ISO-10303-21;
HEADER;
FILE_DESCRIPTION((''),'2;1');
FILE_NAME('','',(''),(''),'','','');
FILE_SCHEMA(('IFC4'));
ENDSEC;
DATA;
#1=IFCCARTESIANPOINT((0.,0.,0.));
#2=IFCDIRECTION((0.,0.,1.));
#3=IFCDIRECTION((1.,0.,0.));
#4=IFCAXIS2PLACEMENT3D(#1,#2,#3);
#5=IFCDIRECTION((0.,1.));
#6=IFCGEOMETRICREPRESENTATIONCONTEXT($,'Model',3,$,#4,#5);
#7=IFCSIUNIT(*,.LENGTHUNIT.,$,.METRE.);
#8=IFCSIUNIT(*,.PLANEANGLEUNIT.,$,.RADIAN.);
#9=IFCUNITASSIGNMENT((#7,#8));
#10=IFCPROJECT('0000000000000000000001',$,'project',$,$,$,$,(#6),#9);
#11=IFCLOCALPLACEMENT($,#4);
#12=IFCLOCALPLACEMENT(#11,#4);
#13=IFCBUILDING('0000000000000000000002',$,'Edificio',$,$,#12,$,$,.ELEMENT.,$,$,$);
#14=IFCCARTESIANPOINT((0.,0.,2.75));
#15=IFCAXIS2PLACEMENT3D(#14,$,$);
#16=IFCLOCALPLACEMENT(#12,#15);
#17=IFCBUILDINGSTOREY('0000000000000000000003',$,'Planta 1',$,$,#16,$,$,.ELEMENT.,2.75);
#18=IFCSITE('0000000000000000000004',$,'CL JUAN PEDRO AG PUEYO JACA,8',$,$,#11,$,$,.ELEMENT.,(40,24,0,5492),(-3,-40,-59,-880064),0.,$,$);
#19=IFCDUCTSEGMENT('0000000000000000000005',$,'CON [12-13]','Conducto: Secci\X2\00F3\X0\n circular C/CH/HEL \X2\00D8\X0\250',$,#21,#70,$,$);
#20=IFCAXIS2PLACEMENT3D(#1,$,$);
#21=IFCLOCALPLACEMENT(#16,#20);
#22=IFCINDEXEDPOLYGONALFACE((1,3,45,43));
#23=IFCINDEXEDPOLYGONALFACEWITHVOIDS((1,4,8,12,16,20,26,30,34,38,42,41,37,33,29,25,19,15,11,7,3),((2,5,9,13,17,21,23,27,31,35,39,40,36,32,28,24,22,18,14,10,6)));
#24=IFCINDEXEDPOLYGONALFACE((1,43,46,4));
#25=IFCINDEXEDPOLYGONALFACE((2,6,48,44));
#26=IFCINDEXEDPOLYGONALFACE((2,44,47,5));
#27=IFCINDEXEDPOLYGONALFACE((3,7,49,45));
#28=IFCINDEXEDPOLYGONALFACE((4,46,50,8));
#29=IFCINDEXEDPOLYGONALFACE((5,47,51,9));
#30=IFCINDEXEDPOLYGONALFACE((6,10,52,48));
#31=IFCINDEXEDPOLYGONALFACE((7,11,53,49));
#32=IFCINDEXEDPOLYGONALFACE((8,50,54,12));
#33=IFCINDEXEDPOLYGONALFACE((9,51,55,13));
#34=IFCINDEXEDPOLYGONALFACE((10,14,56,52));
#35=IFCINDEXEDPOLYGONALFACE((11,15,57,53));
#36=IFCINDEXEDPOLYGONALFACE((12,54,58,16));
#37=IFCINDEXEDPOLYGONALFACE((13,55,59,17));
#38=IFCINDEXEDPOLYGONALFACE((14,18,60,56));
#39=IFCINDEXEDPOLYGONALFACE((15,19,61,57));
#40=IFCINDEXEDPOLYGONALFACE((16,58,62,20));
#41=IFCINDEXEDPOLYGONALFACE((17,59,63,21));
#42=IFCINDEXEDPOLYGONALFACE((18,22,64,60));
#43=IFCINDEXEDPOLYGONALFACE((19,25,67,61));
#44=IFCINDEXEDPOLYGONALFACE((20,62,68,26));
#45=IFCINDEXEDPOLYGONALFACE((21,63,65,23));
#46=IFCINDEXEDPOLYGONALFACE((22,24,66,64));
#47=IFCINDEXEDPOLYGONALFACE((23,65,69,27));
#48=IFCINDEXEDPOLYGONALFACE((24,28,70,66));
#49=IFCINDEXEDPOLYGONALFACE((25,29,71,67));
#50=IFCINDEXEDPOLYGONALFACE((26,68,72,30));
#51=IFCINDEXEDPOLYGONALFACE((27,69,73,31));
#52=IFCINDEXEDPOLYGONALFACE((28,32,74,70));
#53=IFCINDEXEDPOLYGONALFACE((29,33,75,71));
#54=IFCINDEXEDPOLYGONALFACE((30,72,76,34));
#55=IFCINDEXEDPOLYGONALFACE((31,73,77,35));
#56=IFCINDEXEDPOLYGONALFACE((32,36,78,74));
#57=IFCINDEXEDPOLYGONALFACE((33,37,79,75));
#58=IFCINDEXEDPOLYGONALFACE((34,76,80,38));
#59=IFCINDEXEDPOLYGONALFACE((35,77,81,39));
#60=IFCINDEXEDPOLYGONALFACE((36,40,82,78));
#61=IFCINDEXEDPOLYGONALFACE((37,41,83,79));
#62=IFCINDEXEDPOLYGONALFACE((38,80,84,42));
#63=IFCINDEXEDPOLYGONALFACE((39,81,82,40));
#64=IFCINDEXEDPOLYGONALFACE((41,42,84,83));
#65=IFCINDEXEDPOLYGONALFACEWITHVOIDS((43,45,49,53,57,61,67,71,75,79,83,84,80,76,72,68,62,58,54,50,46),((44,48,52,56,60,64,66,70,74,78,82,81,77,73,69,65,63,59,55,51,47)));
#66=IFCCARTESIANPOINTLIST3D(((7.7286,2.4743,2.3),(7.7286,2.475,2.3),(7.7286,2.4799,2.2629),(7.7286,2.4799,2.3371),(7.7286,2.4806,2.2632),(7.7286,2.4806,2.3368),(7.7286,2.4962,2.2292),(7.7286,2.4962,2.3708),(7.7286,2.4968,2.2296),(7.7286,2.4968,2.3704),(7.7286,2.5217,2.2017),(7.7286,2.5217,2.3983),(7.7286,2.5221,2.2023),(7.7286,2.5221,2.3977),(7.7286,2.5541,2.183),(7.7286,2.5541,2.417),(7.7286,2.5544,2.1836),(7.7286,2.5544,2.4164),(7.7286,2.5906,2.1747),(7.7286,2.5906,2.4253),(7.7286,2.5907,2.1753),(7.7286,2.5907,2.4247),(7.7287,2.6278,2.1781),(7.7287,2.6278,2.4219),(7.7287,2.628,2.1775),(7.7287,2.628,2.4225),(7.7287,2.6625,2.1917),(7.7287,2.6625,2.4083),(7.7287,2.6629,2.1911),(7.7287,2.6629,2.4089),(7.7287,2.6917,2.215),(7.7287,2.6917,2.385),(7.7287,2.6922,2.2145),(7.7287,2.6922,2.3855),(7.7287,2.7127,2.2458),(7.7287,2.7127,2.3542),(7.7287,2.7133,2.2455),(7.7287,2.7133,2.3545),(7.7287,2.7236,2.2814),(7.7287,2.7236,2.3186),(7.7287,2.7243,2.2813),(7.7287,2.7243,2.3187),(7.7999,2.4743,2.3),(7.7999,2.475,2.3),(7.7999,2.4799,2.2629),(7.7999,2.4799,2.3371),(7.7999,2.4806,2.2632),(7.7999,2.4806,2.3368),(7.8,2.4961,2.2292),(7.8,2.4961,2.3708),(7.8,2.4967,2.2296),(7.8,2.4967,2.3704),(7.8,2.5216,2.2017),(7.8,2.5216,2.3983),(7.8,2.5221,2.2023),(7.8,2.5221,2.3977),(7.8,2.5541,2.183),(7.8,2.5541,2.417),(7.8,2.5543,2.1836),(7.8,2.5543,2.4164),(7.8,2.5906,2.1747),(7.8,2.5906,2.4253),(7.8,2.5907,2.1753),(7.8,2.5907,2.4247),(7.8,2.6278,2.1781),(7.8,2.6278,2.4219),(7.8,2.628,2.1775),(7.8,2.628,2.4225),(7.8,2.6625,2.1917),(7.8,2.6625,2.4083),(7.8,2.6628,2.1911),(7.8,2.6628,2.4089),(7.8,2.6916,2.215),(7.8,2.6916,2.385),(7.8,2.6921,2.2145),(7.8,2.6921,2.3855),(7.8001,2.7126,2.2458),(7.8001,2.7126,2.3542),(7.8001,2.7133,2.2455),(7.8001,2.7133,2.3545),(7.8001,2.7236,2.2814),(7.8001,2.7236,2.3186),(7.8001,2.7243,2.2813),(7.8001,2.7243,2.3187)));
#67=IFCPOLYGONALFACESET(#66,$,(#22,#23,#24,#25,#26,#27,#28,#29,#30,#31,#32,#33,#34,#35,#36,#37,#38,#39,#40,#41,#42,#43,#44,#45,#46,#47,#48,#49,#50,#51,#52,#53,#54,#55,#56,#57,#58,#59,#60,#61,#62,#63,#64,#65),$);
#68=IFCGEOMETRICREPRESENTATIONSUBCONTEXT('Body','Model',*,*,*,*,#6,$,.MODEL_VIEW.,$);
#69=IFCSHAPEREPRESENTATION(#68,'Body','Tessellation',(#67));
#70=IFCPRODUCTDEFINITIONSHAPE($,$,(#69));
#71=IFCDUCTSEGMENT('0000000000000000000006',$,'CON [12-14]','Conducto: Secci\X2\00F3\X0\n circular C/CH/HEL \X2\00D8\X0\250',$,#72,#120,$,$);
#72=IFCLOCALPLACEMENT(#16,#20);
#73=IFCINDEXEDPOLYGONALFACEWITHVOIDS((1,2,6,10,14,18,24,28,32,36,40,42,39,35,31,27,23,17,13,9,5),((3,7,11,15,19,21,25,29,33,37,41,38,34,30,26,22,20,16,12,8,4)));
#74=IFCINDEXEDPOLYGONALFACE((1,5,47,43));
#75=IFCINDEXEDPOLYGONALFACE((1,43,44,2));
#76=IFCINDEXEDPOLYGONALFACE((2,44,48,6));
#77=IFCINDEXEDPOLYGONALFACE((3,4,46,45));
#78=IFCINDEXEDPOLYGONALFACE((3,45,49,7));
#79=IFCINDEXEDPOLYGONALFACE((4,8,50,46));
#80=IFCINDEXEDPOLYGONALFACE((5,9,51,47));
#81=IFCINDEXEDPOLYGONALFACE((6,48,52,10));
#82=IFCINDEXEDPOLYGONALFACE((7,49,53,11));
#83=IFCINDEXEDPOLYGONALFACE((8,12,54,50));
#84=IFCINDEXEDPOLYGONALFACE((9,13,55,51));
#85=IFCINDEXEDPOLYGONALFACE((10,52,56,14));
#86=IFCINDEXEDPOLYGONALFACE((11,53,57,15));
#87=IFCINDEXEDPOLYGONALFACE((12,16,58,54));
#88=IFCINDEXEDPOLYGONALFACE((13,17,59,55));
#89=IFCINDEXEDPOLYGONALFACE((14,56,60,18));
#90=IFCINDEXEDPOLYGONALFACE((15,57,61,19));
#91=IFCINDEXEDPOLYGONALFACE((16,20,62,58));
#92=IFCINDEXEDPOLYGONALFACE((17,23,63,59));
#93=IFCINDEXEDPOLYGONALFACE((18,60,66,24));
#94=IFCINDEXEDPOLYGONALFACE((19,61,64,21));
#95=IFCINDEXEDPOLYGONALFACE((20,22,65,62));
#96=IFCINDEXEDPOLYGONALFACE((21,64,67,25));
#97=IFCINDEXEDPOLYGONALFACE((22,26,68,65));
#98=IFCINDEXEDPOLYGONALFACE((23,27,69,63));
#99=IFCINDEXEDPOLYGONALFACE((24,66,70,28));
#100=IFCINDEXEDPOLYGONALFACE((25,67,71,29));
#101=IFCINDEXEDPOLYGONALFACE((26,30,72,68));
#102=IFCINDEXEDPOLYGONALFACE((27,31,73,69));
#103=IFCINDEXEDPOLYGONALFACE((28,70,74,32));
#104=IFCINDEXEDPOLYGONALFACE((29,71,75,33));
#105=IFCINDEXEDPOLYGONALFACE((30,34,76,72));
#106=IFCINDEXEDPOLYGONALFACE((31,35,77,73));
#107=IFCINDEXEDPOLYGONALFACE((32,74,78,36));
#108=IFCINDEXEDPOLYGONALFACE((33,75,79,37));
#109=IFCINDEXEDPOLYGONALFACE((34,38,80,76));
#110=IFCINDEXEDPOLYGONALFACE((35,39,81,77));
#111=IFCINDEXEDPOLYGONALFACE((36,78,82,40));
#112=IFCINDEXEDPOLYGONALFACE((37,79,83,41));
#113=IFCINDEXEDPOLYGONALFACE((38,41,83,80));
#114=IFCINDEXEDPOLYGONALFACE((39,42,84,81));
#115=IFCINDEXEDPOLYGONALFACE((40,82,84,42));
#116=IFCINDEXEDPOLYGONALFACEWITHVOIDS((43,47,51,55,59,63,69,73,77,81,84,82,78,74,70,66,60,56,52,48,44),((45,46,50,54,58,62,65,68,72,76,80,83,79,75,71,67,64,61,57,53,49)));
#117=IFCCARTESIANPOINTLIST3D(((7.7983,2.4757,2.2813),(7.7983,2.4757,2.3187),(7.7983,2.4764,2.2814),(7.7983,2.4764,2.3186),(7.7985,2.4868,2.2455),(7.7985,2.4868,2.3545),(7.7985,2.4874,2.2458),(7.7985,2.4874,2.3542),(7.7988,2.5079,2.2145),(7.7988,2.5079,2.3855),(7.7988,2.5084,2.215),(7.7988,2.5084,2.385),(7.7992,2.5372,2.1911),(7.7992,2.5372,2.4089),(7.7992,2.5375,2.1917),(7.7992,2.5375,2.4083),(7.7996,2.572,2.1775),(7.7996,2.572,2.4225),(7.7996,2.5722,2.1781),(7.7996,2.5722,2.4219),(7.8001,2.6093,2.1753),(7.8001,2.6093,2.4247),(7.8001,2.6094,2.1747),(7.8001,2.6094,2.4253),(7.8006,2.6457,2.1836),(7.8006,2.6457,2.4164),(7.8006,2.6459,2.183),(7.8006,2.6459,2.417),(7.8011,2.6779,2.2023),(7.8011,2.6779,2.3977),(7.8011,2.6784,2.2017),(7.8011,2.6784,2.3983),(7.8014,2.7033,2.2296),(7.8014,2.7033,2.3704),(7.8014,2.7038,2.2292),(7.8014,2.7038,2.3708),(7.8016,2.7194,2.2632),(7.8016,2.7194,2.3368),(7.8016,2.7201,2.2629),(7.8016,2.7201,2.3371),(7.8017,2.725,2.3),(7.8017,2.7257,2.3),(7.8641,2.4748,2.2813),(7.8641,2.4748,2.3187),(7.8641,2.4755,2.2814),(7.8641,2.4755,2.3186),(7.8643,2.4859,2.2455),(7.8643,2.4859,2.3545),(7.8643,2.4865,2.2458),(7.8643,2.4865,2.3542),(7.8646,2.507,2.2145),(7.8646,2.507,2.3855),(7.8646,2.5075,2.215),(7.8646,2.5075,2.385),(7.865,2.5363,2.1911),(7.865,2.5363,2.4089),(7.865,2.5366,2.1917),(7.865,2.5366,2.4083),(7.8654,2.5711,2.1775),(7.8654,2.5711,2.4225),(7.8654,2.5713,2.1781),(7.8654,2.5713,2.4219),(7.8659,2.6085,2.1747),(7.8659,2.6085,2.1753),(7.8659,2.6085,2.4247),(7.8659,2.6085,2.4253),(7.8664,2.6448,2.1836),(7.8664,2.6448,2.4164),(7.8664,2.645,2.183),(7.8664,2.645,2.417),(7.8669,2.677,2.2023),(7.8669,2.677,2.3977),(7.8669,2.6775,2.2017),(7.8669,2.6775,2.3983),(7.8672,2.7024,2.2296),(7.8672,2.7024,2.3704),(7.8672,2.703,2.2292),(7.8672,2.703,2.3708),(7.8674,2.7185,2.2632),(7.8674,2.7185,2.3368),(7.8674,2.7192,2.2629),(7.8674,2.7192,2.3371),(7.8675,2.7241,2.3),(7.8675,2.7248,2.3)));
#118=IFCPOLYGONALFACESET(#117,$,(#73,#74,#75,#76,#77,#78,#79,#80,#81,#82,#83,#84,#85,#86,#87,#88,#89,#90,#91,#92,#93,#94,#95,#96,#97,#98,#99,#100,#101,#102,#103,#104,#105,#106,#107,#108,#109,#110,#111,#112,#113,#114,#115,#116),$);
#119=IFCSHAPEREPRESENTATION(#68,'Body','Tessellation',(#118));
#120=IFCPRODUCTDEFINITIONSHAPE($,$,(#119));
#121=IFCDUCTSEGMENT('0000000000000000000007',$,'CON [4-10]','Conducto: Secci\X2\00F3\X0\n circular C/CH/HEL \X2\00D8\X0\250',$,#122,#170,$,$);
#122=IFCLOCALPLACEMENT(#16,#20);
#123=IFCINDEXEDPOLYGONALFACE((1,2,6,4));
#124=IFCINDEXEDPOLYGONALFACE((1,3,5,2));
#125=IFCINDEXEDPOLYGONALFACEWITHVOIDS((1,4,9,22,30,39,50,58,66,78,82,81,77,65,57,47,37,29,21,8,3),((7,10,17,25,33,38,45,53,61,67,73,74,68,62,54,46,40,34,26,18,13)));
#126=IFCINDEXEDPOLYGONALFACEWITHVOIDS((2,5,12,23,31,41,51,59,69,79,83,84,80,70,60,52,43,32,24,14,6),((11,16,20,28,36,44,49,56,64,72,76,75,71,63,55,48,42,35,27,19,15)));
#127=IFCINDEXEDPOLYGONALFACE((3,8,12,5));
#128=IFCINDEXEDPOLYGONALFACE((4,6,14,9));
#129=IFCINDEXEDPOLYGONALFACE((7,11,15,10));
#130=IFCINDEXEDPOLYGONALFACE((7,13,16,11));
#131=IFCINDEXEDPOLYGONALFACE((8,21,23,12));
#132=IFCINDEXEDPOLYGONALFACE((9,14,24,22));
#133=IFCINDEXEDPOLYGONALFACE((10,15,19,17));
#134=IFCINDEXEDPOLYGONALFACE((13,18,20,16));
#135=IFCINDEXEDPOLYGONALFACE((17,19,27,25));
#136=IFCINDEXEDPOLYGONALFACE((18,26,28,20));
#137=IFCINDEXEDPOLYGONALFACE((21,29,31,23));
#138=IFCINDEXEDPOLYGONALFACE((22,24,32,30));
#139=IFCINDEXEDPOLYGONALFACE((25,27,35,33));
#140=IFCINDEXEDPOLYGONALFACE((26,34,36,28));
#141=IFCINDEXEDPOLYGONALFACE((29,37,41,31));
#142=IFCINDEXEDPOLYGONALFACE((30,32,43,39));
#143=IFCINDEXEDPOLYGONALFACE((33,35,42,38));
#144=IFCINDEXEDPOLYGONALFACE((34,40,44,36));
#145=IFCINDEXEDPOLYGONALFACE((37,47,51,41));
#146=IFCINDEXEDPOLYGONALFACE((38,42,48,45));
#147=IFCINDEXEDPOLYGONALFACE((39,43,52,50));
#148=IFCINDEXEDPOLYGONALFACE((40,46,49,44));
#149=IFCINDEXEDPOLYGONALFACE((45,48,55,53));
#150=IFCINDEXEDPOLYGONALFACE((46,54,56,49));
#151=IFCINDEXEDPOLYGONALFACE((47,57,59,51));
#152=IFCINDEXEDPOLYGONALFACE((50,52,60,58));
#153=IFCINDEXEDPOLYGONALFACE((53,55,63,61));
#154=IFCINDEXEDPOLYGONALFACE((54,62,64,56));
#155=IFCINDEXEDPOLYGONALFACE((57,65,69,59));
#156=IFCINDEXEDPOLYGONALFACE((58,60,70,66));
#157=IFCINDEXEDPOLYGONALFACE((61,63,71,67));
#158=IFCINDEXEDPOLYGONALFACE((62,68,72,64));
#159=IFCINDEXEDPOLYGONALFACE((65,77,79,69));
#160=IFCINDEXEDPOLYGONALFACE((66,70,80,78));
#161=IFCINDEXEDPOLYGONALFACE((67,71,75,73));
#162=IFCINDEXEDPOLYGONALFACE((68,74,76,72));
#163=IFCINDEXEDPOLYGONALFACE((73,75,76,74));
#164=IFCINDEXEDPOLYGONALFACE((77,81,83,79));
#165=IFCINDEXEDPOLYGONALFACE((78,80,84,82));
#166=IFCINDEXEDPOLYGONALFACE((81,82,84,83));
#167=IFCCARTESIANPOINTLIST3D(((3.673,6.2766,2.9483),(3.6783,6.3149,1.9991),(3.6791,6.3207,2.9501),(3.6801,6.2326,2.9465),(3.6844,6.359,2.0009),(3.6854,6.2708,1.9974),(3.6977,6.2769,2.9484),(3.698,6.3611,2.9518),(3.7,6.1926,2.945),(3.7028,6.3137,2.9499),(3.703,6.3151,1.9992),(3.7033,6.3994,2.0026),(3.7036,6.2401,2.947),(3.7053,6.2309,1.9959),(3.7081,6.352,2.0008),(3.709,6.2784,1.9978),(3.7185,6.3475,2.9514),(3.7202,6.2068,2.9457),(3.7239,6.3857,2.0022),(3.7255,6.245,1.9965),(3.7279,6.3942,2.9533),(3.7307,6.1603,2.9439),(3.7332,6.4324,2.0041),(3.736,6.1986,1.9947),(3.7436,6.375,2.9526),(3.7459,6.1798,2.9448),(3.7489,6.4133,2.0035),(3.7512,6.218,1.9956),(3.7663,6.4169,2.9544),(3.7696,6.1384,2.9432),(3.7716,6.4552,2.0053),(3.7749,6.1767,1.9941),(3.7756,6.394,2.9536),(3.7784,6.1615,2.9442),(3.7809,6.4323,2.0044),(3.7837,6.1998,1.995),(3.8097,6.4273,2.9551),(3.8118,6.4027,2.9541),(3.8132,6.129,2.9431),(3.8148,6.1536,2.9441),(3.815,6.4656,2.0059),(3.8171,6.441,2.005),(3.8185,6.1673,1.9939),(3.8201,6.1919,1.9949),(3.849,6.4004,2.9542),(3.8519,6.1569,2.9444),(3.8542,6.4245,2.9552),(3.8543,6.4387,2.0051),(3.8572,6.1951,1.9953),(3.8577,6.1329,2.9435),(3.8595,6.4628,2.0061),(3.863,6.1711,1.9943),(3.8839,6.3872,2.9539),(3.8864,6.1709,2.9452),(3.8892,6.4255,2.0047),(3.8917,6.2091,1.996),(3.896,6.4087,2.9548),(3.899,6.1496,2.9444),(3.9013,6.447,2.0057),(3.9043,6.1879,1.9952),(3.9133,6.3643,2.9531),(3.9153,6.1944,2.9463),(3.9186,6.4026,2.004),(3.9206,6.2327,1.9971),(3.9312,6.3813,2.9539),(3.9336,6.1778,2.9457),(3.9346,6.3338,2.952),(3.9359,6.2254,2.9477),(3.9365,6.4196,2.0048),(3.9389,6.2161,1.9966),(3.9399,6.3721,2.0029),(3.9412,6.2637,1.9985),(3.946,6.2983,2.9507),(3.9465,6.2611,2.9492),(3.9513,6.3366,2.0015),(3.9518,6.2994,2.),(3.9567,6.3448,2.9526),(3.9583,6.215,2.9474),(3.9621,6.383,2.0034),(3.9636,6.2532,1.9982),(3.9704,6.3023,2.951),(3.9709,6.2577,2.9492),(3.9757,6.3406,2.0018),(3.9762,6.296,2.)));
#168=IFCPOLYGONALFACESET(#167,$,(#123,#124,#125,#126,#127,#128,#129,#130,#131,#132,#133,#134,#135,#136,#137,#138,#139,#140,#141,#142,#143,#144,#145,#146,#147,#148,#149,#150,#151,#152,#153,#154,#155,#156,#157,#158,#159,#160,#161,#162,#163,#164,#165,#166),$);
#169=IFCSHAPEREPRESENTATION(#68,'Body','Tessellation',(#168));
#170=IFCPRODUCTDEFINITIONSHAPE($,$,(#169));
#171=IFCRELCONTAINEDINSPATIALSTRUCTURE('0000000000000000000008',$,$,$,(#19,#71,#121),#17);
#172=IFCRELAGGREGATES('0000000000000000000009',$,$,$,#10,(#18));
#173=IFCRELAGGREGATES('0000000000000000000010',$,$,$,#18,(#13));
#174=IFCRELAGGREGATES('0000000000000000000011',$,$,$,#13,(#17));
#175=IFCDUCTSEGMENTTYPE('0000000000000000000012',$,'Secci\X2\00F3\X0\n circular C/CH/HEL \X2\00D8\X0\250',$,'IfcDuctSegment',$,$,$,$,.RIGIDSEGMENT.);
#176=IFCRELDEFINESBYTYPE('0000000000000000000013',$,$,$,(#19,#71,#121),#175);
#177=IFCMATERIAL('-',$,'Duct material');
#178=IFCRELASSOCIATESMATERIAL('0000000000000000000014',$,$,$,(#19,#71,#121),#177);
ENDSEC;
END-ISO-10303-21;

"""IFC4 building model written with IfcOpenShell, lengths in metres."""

from ifc_helpers import new_model, si_unit, direction, frame, origin_with_axes, origin_2d_with_axis, place, context, subcontext, project, spatial, hollow_circle, extrude, material, type_object, element, save


model = new_model("IFC4")

# Units and contexts
model_context = context("Model", 3, world=origin_with_axes(), true_north=direction((0.0, 1.0)))
body_context = subcontext(model_context, "Body", "Model", "MODEL_VIEW")
ifc_project = project(units=[si_unit("LENGTHUNIT", "METRE"), si_unit("PLANEANGLEUNIT", "RADIAN")], contexts=[model_context])

# Site, building, storey
site_placement = place(None, origin_with_axes())
site = spatial("IfcSite", under=ifc_project, at=site_placement, Name="CL JUAN PEDRO AG PUEYO JACA,8", CompositionType="ELEMENT", RefLatitude=(40, 24, 0, 5492), RefLongitude=(-3, -40, -59, -880064), RefElevation=0.0)
building_placement = place(site_placement, origin_with_axes())
building = spatial("IfcBuilding", under=site, at=building_placement, Name="Edificio", CompositionType="ELEMENT")
storey_placement = place(building_placement, frame((0.0, 0.0, 2.75)))
storey = spatial("IfcBuildingStorey", under=building, at=storey_placement, Name="Planta 1", CompositionType="ELEMENT", Elevation=2.75)

# Shared definitions
ifc_material_1 = material(Name="-", Category="Duct material")

# Duct segments
duct_segment_type_1 = type_object("IfcDuctSegmentType", Name="Sección circular C/CH/HEL Ø250", ApplicableOccurrence="IfcDuctSegment", PredefinedType="RIGIDSEGMENT")
duct_segment_1_placement = place(storey_placement, frame((0.0, 0.0, -2.75), z_axis=(0.0, 0.0, 1.0), x_axis=(1.0, 0.0, 0.0)))
element("IfcDuctSegment", 1, at=duct_segment_1_placement, inside=storey, type_object=duct_segment_type_1, material=ifc_material_1, Name="CON [12-13]", Description="Conducto: Sección circular C/CH/HEL Ø250", context=body_context, shape_type="SweptSolid", body=[
    extrude(hollow_circle(Radius=0.1257, WallThickness=0.0007, at=origin_2d_with_axis()), frame((7.8, 2.6, 5.05), z_axis=(-1.0, 0.000478, 0.0), x_axis=(-0.000478, -1.0, 0.0)), (0.0, 0.0, 1.0), 0.0714),
])
duct_segment_2_placement = place(storey_placement, frame((0.0, 0.0, -2.75), z_axis=(0.0, 0.0, 1.0), x_axis=(1.0, 0.0, 0.0)))
element("IfcDuctSegment", 2, at=duct_segment_2_placement, inside=storey, type_object=duct_segment_type_1, material=ifc_material_1, Name="CON [12-14]", Description="Conducto: Sección circular C/CH/HEL Ø250", context=body_context, shape_type="SweptSolid", body=[
    extrude(hollow_circle(Radius=0.1257, WallThickness=0.0007, at=origin_2d_with_axis()), frame((7.8, 2.6, 5.05), z_axis=(0.999909, -0.013515, 0.0), x_axis=(0.013515, 0.999909, 0.0)), (0.0, 0.0, 1.0), 0.0658),
])
duct_segment_3_placement = place(storey_placement, frame((0.0, 0.0, -2.75), z_axis=(0.0, 0.0, 1.0), x_axis=(1.0, 0.0, 0.0)))
element("IfcDuctSegment", 3, at=duct_segment_3_placement, inside=storey, type_object=duct_segment_type_1, material=ifc_material_1, Name="CON [4-10]", Description="Conducto: Sección circular C/CH/HEL Ø250", context=body_context, shape_type="SweptSolid", body=[
    extrude(hollow_circle(Radius=0.1497, WallThickness=0.0247, at=origin_2d_with_axis()), frame((3.828, 6.3166, 4.75), z_axis=(-0.005594, -0.040302, 0.999172), x_axis=(0.990505, -0.137474, 0.0)), (0.0, 0.0, 1.0), 0.95),
])

save(model, "model.ifc")
